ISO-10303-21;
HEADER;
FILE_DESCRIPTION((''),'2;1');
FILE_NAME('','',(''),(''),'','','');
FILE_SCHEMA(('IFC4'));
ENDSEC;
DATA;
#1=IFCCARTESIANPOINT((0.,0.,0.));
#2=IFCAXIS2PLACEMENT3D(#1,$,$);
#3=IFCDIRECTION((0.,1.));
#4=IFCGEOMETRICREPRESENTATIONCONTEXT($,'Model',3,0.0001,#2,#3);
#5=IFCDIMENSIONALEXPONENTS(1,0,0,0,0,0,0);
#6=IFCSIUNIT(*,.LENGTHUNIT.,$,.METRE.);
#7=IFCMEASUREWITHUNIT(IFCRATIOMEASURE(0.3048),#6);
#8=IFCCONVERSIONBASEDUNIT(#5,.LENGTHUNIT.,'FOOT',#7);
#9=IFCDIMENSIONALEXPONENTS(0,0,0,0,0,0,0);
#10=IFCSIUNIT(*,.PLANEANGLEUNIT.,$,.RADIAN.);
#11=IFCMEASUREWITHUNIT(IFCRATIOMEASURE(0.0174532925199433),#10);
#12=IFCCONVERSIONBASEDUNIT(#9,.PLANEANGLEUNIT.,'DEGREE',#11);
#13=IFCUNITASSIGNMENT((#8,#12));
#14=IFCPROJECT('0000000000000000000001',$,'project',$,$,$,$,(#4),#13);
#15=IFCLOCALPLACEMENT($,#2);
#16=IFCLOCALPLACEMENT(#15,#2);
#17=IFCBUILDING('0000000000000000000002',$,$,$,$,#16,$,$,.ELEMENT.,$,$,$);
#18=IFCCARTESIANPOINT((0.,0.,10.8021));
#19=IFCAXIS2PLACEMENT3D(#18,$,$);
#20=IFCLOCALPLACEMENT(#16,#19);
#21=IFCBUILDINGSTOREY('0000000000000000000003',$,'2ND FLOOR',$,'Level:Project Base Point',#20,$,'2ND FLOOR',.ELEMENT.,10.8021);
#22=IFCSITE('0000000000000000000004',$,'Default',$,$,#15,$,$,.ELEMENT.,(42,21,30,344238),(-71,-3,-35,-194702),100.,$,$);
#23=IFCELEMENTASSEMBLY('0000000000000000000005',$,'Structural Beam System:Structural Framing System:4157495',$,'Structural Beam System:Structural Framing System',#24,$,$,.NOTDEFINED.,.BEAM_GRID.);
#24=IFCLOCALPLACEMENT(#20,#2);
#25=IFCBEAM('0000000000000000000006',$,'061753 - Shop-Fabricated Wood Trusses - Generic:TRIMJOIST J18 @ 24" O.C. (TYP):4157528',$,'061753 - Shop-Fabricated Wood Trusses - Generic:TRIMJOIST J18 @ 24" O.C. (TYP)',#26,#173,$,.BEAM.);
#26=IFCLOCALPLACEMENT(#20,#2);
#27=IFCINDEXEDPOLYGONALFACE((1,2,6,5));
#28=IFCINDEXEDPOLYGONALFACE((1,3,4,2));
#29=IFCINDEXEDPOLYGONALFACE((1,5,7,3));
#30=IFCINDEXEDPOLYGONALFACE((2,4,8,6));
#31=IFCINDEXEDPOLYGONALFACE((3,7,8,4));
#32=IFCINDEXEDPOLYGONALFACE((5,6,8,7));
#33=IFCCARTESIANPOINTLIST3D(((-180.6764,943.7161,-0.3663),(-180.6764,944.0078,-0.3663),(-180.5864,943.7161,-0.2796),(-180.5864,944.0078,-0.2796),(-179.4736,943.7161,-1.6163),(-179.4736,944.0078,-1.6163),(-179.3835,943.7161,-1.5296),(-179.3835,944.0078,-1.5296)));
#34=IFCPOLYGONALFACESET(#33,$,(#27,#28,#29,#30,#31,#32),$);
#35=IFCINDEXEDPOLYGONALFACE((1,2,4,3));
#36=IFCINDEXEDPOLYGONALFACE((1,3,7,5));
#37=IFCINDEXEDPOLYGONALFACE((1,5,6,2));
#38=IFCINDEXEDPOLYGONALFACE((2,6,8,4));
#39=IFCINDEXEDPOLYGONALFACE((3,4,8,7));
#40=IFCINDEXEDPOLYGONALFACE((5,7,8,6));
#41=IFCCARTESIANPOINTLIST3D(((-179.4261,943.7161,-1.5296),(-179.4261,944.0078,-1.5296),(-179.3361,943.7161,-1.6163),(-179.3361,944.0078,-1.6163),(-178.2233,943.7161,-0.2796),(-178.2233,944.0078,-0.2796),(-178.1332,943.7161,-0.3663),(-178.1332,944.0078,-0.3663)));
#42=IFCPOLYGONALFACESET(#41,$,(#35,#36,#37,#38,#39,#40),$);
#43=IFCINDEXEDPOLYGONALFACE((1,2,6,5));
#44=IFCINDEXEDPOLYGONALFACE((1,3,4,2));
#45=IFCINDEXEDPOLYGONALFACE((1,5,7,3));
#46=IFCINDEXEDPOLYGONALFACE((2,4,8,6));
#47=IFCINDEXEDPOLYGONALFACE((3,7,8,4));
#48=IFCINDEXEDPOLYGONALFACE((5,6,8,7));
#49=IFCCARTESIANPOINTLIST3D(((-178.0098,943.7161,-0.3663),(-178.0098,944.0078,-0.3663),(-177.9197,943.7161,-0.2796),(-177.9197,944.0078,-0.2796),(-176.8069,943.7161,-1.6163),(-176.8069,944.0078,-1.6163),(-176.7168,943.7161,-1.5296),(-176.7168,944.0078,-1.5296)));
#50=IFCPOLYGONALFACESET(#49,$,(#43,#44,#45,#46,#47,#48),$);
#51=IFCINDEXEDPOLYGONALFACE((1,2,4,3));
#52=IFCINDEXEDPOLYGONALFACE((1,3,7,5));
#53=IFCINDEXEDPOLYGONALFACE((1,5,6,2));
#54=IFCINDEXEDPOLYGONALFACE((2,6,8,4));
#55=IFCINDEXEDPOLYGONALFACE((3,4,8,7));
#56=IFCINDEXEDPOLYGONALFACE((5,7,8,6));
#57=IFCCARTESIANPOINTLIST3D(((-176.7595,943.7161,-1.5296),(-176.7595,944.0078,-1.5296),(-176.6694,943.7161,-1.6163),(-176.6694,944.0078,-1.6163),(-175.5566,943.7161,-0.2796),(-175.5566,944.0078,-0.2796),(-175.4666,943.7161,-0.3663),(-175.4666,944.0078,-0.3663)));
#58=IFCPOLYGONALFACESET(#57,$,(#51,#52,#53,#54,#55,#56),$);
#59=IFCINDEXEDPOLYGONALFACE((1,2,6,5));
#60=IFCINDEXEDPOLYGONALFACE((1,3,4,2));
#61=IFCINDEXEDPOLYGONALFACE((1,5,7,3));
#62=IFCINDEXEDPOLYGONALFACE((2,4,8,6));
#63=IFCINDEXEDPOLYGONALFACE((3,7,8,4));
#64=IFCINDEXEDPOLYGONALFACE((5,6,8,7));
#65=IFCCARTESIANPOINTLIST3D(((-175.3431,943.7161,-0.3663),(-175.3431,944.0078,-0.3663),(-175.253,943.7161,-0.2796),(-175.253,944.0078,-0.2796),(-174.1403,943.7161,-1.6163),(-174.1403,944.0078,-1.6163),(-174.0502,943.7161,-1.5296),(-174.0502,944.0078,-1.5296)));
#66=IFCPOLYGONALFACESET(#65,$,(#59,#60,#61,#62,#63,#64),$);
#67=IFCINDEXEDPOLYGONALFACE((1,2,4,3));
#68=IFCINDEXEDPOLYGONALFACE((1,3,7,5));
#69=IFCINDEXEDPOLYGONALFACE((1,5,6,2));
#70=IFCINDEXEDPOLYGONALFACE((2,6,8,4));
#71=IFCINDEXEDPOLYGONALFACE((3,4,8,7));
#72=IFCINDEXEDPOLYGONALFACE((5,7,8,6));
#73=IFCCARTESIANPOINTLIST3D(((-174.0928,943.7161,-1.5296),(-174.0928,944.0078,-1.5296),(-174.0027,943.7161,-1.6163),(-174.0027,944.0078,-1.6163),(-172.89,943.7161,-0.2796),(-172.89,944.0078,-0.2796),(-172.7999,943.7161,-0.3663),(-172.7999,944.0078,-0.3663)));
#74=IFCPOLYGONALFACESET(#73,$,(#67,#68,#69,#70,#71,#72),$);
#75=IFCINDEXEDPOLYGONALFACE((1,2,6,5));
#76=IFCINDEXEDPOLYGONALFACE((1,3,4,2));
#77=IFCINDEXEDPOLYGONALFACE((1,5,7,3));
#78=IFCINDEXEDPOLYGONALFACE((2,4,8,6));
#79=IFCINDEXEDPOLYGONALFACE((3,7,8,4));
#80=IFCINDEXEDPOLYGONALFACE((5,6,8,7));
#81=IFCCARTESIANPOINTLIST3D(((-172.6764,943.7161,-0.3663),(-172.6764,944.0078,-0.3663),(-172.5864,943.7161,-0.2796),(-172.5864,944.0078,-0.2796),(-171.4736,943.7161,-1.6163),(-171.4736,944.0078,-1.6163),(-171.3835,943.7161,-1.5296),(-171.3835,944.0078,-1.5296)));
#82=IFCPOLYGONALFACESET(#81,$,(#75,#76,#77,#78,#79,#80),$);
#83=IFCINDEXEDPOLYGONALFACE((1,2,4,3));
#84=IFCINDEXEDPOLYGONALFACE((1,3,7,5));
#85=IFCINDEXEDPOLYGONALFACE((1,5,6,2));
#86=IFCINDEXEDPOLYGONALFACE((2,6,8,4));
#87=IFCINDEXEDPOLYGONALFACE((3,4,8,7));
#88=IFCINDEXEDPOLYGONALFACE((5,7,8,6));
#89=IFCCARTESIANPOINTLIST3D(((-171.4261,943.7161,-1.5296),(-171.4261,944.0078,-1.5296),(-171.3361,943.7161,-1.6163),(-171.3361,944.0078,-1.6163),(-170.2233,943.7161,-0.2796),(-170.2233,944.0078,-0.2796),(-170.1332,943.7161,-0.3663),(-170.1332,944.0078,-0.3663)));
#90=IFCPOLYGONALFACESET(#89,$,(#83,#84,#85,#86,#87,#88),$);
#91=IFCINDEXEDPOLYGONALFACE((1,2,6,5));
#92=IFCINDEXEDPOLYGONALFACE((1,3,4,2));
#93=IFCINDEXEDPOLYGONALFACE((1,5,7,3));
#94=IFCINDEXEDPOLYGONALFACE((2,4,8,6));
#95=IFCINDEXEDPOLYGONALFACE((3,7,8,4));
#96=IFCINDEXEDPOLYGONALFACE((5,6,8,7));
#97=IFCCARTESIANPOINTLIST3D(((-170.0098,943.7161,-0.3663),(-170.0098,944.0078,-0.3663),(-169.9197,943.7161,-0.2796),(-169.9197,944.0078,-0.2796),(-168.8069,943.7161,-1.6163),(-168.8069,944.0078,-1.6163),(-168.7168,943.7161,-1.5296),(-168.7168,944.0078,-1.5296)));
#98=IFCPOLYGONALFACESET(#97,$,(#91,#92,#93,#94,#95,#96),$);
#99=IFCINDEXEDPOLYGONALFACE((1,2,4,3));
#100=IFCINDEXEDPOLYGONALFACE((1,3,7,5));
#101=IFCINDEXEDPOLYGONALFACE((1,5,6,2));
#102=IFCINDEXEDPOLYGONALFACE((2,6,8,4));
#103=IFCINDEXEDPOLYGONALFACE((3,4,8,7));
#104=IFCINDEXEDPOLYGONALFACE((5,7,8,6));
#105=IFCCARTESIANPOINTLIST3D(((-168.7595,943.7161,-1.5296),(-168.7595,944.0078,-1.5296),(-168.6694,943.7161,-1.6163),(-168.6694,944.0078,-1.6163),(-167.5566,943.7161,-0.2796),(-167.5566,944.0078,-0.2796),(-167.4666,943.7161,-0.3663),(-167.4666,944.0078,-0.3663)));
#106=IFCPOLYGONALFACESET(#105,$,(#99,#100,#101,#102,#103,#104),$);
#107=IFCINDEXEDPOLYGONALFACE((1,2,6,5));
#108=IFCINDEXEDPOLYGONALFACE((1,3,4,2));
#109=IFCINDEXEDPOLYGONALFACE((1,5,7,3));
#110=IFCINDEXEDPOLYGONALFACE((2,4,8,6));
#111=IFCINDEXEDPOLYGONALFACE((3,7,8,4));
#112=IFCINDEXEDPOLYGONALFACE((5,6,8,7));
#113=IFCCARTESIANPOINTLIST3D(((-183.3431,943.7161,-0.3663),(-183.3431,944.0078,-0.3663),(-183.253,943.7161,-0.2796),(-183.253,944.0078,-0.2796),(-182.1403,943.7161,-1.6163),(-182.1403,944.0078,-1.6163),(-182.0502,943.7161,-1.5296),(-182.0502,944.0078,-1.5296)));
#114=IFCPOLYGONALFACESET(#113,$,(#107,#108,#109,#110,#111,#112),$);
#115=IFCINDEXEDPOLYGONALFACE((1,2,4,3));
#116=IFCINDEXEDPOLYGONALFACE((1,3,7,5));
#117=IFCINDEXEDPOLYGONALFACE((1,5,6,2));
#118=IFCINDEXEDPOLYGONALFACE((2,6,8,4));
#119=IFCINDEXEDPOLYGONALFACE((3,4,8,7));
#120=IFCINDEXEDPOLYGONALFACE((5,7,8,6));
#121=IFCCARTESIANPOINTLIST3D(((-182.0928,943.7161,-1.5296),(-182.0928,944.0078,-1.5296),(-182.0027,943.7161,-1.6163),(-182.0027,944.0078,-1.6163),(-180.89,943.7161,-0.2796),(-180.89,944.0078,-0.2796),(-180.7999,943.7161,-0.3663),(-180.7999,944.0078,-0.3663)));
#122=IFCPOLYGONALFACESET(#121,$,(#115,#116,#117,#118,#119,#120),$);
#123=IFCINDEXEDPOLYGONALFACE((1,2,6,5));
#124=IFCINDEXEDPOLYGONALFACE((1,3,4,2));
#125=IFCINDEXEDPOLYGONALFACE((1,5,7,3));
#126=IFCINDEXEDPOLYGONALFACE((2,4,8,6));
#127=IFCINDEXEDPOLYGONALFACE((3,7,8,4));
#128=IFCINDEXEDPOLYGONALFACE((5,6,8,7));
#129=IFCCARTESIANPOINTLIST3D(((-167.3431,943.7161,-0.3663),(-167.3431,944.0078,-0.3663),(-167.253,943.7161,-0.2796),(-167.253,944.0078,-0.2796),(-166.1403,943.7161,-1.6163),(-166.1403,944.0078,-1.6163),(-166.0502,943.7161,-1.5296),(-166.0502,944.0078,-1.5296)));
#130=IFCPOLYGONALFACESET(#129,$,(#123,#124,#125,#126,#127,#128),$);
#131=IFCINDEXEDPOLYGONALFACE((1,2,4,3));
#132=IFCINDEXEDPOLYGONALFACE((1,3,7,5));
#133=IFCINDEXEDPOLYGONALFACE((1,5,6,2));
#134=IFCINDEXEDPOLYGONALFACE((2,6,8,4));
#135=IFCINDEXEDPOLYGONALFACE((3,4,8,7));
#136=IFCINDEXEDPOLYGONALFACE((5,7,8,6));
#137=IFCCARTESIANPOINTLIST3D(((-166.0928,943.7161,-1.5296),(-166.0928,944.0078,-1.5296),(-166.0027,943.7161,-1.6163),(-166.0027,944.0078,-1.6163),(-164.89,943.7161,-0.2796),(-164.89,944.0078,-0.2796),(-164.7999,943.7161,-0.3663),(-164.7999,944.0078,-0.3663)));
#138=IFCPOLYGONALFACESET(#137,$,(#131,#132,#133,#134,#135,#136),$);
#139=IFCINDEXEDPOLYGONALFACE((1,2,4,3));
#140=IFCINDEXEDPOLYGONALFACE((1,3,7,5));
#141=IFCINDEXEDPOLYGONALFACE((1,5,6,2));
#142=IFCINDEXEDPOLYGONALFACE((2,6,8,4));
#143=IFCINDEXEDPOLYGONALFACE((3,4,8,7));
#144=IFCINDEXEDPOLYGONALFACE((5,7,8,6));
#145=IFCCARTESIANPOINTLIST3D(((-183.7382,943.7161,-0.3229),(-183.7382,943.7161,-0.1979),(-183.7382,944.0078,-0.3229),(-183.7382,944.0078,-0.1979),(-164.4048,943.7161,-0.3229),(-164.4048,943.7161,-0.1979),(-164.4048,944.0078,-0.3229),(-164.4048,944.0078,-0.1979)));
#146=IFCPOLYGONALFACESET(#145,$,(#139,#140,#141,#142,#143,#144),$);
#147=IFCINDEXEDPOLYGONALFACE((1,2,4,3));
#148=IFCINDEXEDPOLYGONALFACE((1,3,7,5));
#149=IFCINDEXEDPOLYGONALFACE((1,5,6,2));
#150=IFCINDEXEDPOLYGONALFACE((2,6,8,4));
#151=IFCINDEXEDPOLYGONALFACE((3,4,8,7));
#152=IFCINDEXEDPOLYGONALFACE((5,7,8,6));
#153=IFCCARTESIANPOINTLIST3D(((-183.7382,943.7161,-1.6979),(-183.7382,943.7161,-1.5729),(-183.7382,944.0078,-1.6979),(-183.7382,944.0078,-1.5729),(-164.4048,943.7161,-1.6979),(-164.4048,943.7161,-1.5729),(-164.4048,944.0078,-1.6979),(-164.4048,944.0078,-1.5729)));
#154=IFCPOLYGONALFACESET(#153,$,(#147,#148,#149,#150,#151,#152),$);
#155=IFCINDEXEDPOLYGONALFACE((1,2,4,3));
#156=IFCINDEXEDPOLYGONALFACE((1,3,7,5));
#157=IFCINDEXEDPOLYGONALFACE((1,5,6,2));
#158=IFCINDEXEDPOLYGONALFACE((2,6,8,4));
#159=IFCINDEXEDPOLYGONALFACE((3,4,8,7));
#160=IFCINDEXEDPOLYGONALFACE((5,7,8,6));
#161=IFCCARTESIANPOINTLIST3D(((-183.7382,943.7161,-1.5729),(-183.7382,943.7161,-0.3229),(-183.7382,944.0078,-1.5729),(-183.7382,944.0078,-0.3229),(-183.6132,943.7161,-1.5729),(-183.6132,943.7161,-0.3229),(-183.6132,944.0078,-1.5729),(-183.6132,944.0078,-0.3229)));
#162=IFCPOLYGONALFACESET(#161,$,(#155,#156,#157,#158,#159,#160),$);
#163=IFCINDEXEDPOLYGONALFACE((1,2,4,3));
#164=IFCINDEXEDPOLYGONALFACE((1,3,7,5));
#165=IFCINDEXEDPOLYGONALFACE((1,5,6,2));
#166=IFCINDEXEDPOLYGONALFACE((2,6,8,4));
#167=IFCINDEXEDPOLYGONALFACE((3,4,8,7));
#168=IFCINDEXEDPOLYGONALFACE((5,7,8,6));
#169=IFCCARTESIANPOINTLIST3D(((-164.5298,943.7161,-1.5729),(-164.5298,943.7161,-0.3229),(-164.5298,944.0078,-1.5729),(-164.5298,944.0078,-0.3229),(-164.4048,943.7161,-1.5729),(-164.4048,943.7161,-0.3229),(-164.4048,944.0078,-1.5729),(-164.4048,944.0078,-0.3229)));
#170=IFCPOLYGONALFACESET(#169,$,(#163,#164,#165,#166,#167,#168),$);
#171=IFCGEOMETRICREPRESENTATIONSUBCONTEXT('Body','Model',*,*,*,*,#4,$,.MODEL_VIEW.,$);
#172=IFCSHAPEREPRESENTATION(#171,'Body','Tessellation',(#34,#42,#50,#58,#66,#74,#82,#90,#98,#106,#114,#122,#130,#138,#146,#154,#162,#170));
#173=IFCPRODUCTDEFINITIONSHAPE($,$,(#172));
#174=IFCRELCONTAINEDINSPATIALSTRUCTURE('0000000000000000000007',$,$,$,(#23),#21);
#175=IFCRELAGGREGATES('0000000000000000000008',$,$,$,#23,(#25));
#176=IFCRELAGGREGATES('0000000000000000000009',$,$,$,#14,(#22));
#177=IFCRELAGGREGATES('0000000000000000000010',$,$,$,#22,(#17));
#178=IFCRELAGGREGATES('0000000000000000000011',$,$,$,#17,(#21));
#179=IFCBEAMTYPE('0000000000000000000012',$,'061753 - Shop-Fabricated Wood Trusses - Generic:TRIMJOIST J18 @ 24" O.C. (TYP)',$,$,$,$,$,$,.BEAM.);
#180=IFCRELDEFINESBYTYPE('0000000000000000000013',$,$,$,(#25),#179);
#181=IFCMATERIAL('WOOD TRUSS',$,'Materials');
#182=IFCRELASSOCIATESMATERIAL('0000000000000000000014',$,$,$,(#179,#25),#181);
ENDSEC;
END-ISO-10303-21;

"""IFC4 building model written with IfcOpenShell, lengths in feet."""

from ifc_helpers import new_model, entity, si_unit, converted_unit, direction, frame, frame_2d, origin, origin_2d_with_axis, place, context, subcontext, project, spatial, rectangle, extrude, source, transform, mapped, material, material_profile, profile_set, profile_usage, type_object, type_shapes, element, aggregate, save


model = new_model("IFC4")

# Units and contexts
model_context = context("Model", 3, precision=0.0001, world=origin(), true_north=direction((0.0, 1.0)))
body_context = subcontext(model_context, "Body", "Model", "MODEL_VIEW")
ifc_project = project(units=[converted_unit("LENGTHUNIT", "FOOT", entity("IfcRatioMeasure", 0.3048), si_unit("LENGTHUNIT", "METRE"), dimensions=[1, 0, 0, 0, 0, 0, 0]), converted_unit("PLANEANGLEUNIT", "DEGREE", entity("IfcRatioMeasure", 0.0174532925199433), si_unit("PLANEANGLEUNIT", "RADIAN"), dimensions=[0, 0, 0, 0, 0, 0, 0])], contexts=[model_context])

# Site, building, storey
site_placement = place(None, origin())
site = spatial("IfcSite", under=ifc_project, at=site_placement, Name="Default", CompositionType="ELEMENT", RefLatitude=(42, 21, 30, 344238), RefLongitude=(-71, -3, -35, -194702), RefElevation=100.0)
building_placement = place(site_placement, origin())
building = spatial("IfcBuilding", under=site, at=building_placement, CompositionType="ELEMENT")
storey_placement = place(building_placement, frame((0.0, 0.0, 10.8021)))
storey = spatial("IfcBuildingStorey", under=building, at=storey_placement, Name="2ND FLOOR", ObjectType="Level:Project Base Point", LongName="2ND FLOOR", CompositionType="ELEMENT", Elevation=10.8021)

# Element assembly, beam
assembly_1_placement = place(storey_placement, origin())
assembly_1 = element("IfcElementAssembly", 1, at=assembly_1_placement, inside=storey, Name="Structural Beam System:Structural Framing System:4157495", ObjectType="Structural Beam System:Structural Framing System", AssemblyPlace="NOTDEFINED", PredefinedType="BEAM_GRID")
ifc_material_1 = material(Name="WOOD TRUSS", Category="Materials")
ifc_material_profile_1 = material_profile(ifc_material_1, rectangle(XDim=1.7347, YDim=0.125, at=frame_2d((0.0, 0.0), x_axis=(1.0, 0.0))), Name="TRIMJOIST J18 @ 24\" O.C. (TYP)")
ifc_material_profile_2 = material_profile(ifc_material_1, rectangle(XDim=1.7347, YDim=0.125, at=frame_2d((0.0, 0.0), x_axis=(1.0, 0.0))), Name="TRIMJOIST J18 @ 24\" O.C. (TYP)")
ifc_material_profile_3 = material_profile(ifc_material_1, rectangle(XDim=1.7347, YDim=0.125, at=frame_2d((0.0, 0.0), x_axis=(1.0, 0.0))), Name="TRIMJOIST J18 @ 24\" O.C. (TYP)")
ifc_material_profile_4 = material_profile(ifc_material_1, rectangle(XDim=1.7347, YDim=0.125, at=frame_2d((0.0, 0.0), x_axis=(1.0, 0.0))), Name="TRIMJOIST J18 @ 24\" O.C. (TYP)")
ifc_material_profile_5 = material_profile(ifc_material_1, rectangle(XDim=1.7347, YDim=0.125, at=frame_2d((0.0, 0.0), x_axis=(1.0, 0.0))), Name="TRIMJOIST J18 @ 24\" O.C. (TYP)")
ifc_material_profile_6 = material_profile(ifc_material_1, rectangle(XDim=1.7347, YDim=0.125, at=frame_2d((0.0, 0.0), x_axis=(1.0, 0.0))), Name="TRIMJOIST J18 @ 24\" O.C. (TYP)")
ifc_material_profile_7 = material_profile(ifc_material_1, rectangle(XDim=1.7347, YDim=0.125, at=frame_2d((0.0, 0.0), x_axis=(1.0, 0.0))), Name="TRIMJOIST J18 @ 24\" O.C. (TYP)")
ifc_material_profile_8 = material_profile(ifc_material_1, rectangle(XDim=1.7347, YDim=0.125, at=frame_2d((0.0, 0.0), x_axis=(1.0, 0.0))), Name="TRIMJOIST J18 @ 24\" O.C. (TYP)")
ifc_material_profile_9 = material_profile(ifc_material_1, rectangle(XDim=1.7347, YDim=0.125, at=frame_2d((0.0, 0.0), x_axis=(1.0, 0.0))), Name="TRIMJOIST J18 @ 24\" O.C. (TYP)")
ifc_material_profile_10 = material_profile(ifc_material_1, rectangle(XDim=1.7347, YDim=0.125, at=origin_2d_with_axis()), Name="TRIMJOIST J18 @ 24\" O.C. (TYP)")
ifc_material_profile_11 = material_profile(ifc_material_1, rectangle(XDim=0.125, YDim=0.2917, at=origin_2d_with_axis()), Name="TRIMJOIST J18 @ 24\" O.C. (TYP)")
ifc_material_profile_12 = material_profile(ifc_material_1, rectangle(XDim=0.125, YDim=0.2917, at=origin_2d_with_axis()), Name="TRIMJOIST J18 @ 24\" O.C. (TYP)")
ifc_material_profile_13 = material_profile(ifc_material_1, rectangle(XDim=1.25, YDim=0.2917, at=origin_2d_with_axis()), Name="TRIMJOIST J18 @ 24\" O.C. (TYP)")
ifc_material_profile_14 = material_profile(ifc_material_1, rectangle(XDim=1.25, YDim=0.2917, at=origin_2d_with_axis()), Name="TRIMJOIST J18 @ 24\" O.C. (TYP)")
ifc_profile_set_1 = profile_set([ifc_material_profile_1, ifc_material_profile_2, ifc_material_profile_3, ifc_material_profile_4, ifc_material_profile_5, ifc_material_profile_6, ifc_material_profile_7, ifc_material_profile_8, ifc_material_profile_9, ifc_material_profile_10, ifc_material_profile_11, ifc_material_profile_12, ifc_material_profile_13, ifc_material_profile_14], Name="TRIMJOIST J18 @ 24\" O.C. (TYP)")
ifc_profile_usage_1 = profile_usage(ifc_profile_set_1, cardinal=8)
beam_type_1 = type_object("IfcBeamType", Name="061753 - Shop-Fabricated Wood Trusses - Generic:TRIMJOIST J18 @ 24\" O.C. (TYP)", PredefinedType="BEAM", material=ifc_profile_set_1)
shared_shape_1 = source(origin(), body_context, "Body", "SweptSolid", [
    extrude(rectangle(XDim=1.7347, YDim=0.125, at=frame_2d((0.0, 0.0), x_axis=(1.0, 0.0))), frame((5.9585, -0.1458, 0.0), z_axis=(0.0, 1.0, 0.0), x_axis=(0.693383, 0.0, 0.720569)), (0.0, 0.0, 1.0), 0.2917),
    extrude(rectangle(XDim=1.7347, YDim=0.125, at=origin_2d_with_axis()), frame((4.7082, -0.1458, 0.0), z_axis=(0.0, 1.0, 0.0), x_axis=(0.693383, 0.0, -0.720569)), (0.0, 0.0, 1.0), 0.2917),
    extrude(rectangle(XDim=1.7347, YDim=0.125, at=frame_2d((0.0, 0.0), x_axis=(1.0, 0.0))), frame((3.2918, -0.1458, 0.0), z_axis=(0.0, 1.0, 0.0), x_axis=(0.693383, 0.0, 0.720569)), (0.0, 0.0, 1.0), 0.2917),
    extrude(rectangle(XDim=1.7347, YDim=0.125, at=frame_2d((0.0, 0.0), x_axis=(1.0, 0.0))), frame((2.0415, -0.1458, 0.0), z_axis=(0.0, 1.0, 0.0), x_axis=(0.693383, 0.0, -0.720569)), (0.0, 0.0, 1.0), 0.2917),
    extrude(rectangle(XDim=1.7347, YDim=0.125, at=frame_2d((0.0, 0.0), x_axis=(1.0, 0.0))), frame((0.6251, -0.1458, 0.0), z_axis=(0.0, 1.0, 0.0), x_axis=(0.693383, 0.0, 0.720569)), (0.0, 0.0, 1.0), 0.2917),
    extrude(rectangle(XDim=1.7347, YDim=0.125, at=frame_2d((0.0, 0.0), x_axis=(1.0, 0.0))), frame((-0.6251, -0.1458, 0.0), z_axis=(0.0, 1.0, 0.0), x_axis=(0.693383, 0.0, -0.720569)), (0.0, 0.0, 1.0), 0.2917),
    extrude(rectangle(XDim=1.7347, YDim=0.125, at=frame_2d((0.0, 0.0), x_axis=(1.0, 0.0))), frame((-2.0415, -0.1458, 0.0), z_axis=(0.0, 1.0, 0.0), x_axis=(0.693383, 0.0, 0.720569)), (0.0, 0.0, 1.0), 0.2917),
    extrude(rectangle(XDim=1.7347, YDim=0.125, at=origin_2d_with_axis()), frame((-3.2918, -0.1458, 0.0), z_axis=(0.0, 1.0, 0.0), x_axis=(0.693383, 0.0, -0.720569)), (0.0, 0.0, 1.0), 0.2917),
    extrude(rectangle(XDim=1.7347, YDim=0.125, at=frame_2d((0.0, 0.0), x_axis=(1.0, 0.0))), frame((-4.7082, -0.1458, 0.0), z_axis=(0.0, 1.0, 0.0), x_axis=(0.693383, 0.0, 0.720569)), (0.0, 0.0, 1.0), 0.2917),
    extrude(rectangle(XDim=1.7347, YDim=0.125, at=frame_2d((0.0, 0.0), x_axis=(1.0, 0.0))), frame((-5.9585, -0.1458, 0.0), z_axis=(0.0, 1.0, 0.0), x_axis=(0.693383, 0.0, -0.720569)), (0.0, 0.0, 1.0), 0.2917),
    extrude(rectangle(XDim=1.7347, YDim=0.125, at=frame_2d((0.0, 0.0), x_axis=(1.0, 0.0))), frame((8.6251, -0.1458, 0.0), z_axis=(0.0, 1.0, 0.0), x_axis=(0.693383, 0.0, 0.720569)), (0.0, 0.0, 1.0), 0.2917),
    extrude(rectangle(XDim=1.7347, YDim=0.125, at=origin_2d_with_axis()), frame((7.3749, -0.1458, 0.0), z_axis=(0.0, 1.0, 0.0), x_axis=(0.693383, 0.0, -0.720569)), (0.0, 0.0, 1.0), 0.2917),
    extrude(rectangle(XDim=1.7347, YDim=0.125, at=frame_2d((0.0, 0.0), x_axis=(1.0, 0.0))), frame((-7.3749, -0.1458, 0.0), z_axis=(0.0, 1.0, 0.0), x_axis=(0.693383, 0.0, 0.720569)), (0.0, 0.0, 1.0), 0.2917),
    extrude(rectangle(XDim=1.7347, YDim=0.125, at=origin_2d_with_axis()), frame((-8.6251, -0.1458, 0.0), z_axis=(0.0, 1.0, 0.0), x_axis=(0.693383, 0.0, -0.720569)), (0.0, 0.0, 1.0), 0.2917),
    extrude(rectangle(XDim=0.125, YDim=0.2917, at=origin_2d_with_axis()), frame((-9.6667, 0.0, 0.6875), z_axis=(1.0, 0.0, 0.0), x_axis=(0.0, 0.0, -1.0)), (0.0, 0.0, 1.0), 19.3333),
    extrude(rectangle(XDim=0.125, YDim=0.2917, at=origin_2d_with_axis()), frame((-9.6667, 0.0, -0.6875), z_axis=(1.0, 0.0, 0.0), x_axis=(0.0, 0.0, -1.0)), (0.0, 0.0, 1.0), 19.3333),
    extrude(rectangle(XDim=1.25, YDim=0.2917, at=origin_2d_with_axis()), frame((9.5417, 0.0, 0.0), z_axis=(1.0, 0.0, 0.0), x_axis=(0.0, 0.0, -1.0)), (0.0, 0.0, 1.0), 0.125),
    extrude(rectangle(XDim=1.25, YDim=0.2917, at=origin_2d_with_axis()), frame((-9.6667, 0.0, 0.0), z_axis=(1.0, 0.0, 0.0), x_axis=(0.0, 0.0, -1.0)), (0.0, 0.0, 1.0), 0.125),
])
type_shapes(beam_type_1, [shared_shape_1])
beam_1_placement = place(assembly_1_placement, frame((-174.0715, 943.8619, -0.9479), z_axis=(0.0, 0.0, 1.0), x_axis=(-1.0, 0.0, 0.0)))
beam_1 = element("IfcBeam", 2, at=beam_1_placement, type_object=beam_type_1, material=ifc_profile_usage_1, Name="061753 - Shop-Fabricated Wood Trusses - Generic:TRIMJOIST J18 @ 24\" O.C. (TYP):4157528", ObjectType="061753 - Shop-Fabricated Wood Trusses - Generic:TRIMJOIST J18 @ 24\" O.C. (TYP)", PredefinedType="BEAM", context=body_context, shape_type="MappedRepresentation", body=[
    mapped(shared_shape_1, transform((0.0, 0.0, 0.0), scale=1.0)),
])
aggregate(assembly_1, [beam_1])

save(model, "model.ifc")
